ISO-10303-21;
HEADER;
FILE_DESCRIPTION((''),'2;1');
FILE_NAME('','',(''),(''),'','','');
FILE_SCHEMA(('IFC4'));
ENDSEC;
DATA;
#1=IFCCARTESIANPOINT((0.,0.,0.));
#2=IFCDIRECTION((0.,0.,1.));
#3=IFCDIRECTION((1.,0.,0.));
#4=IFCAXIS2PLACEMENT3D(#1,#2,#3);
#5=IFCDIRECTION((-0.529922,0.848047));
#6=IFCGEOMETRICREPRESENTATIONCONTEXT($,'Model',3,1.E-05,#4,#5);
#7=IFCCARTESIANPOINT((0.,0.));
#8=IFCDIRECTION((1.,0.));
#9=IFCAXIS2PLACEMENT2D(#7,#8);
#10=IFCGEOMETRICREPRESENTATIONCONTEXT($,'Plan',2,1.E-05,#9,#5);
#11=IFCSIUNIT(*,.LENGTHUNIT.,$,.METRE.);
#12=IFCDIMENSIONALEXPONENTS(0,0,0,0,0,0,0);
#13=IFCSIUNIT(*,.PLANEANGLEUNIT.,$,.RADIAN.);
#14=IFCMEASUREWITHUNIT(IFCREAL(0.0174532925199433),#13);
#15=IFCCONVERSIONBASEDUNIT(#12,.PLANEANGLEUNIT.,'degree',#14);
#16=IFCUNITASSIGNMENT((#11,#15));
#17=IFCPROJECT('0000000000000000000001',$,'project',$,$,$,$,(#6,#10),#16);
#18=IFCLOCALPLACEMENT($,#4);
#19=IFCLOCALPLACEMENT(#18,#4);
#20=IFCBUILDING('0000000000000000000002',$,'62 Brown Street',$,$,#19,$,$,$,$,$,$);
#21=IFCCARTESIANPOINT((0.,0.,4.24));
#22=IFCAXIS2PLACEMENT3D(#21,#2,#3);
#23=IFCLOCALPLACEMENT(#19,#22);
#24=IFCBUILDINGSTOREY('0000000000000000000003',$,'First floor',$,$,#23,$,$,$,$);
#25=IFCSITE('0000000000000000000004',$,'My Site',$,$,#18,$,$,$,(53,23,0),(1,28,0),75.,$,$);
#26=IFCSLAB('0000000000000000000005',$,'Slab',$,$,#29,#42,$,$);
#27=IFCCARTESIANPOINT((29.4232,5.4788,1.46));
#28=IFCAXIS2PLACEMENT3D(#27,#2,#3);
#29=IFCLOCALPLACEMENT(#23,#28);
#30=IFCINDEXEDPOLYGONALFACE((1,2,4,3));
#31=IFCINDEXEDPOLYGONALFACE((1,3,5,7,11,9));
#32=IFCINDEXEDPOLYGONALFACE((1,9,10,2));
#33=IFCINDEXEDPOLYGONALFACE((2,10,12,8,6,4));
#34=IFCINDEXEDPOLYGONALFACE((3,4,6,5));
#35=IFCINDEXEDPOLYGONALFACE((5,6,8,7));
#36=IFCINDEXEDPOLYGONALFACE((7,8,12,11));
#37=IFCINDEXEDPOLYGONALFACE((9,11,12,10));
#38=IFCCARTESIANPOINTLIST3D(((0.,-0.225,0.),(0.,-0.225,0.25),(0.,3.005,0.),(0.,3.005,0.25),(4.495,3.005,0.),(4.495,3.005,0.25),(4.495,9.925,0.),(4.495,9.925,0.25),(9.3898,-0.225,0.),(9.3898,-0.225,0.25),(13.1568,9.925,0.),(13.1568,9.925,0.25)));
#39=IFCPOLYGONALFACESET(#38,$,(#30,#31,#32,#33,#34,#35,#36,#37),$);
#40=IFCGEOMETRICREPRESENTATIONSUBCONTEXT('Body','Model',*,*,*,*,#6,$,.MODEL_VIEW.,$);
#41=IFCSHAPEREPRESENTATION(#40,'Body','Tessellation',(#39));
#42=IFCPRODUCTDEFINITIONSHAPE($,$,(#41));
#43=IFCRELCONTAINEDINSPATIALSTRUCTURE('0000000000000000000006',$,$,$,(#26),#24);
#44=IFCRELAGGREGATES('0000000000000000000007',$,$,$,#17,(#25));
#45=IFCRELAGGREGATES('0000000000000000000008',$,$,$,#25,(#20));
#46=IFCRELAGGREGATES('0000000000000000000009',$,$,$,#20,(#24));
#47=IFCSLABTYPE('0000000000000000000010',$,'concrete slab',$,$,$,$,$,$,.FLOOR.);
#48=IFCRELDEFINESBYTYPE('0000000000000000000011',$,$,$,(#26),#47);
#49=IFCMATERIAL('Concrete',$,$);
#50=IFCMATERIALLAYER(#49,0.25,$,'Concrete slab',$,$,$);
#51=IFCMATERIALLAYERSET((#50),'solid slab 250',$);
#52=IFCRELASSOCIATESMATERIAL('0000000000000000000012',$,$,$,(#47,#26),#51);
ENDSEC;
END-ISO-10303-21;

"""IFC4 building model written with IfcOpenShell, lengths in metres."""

from ifc_helpers import new_model, entity, si_unit, converted_unit, direction, frame, origin_with_axes, origin_2d_with_axis, place, context, subcontext, project, spatial, line, indexed_curve, outline, extrude, material, layer, layer_set, layer_usage, type_object, element, save


model = new_model("IFC4")

# Units and contexts
model_context = context("Model", 3, precision=1e-05, world=origin_with_axes(), true_north=direction((-0.529922, 0.848047)))
plan_context = context("Plan", 2, precision=1e-05, world=origin_2d_with_axis(), true_north=direction((-0.529922, 0.848047)))
body_context_1 = subcontext(model_context, "Body", "Model", "MODEL_VIEW")
ifc_project = project(units=[si_unit("LENGTHUNIT", "METRE"), converted_unit("PLANEANGLEUNIT", "degree", entity("IfcReal", 0.0174532925199433), si_unit("PLANEANGLEUNIT", "RADIAN"), dimensions=[0, 0, 0, 0, 0, 0, 0])], contexts=[model_context, plan_context])

# Site, building, storey
site_placement = place(None, origin_with_axes())
site = spatial("IfcSite", under=ifc_project, at=site_placement, Name="My Site", RefLatitude=(53, 23, 0), RefLongitude=(1, 28, 0), RefElevation=75.0)
building_placement = place(site_placement, origin_with_axes())
building = spatial("IfcBuilding", under=site, at=building_placement, Name="62 Brown Street")
storey_placement = place(building_placement, frame((0.0, 0.0, 4.24), z_axis=(0.0, 0.0, 1.0), x_axis=(1.0, 0.0, 0.0)))
storey = spatial("IfcBuildingStorey", under=building, at=storey_placement, Name="First floor")

# Slab
ifc_material_1 = material(Name="Concrete")
ifc_layer_1 = layer(ifc_material_1, 0.25, Name="Concrete slab")
ifc_layer_set_1 = layer_set([ifc_layer_1], Name="solid slab 250")
slab_type = type_object("IfcSlabType", Name="concrete slab", PredefinedType="FLOOR", material=ifc_layer_set_1)
ifc_layer_usage_1 = layer_usage(ifc_layer_set_1, "AXIS3", "POSITIVE", 0.0)
slab_1_placement = place(storey_placement, frame((29.4232, 5.4788, 1.46), z_axis=(0.0, 0.0, 1.0), x_axis=(1.0, 0.0, 0.0)))
element("IfcSlab", 1, at=slab_1_placement, inside=storey, type_object=slab_type, material=ifc_layer_usage_1, Name="Slab", context=body_context_1, shape_type="SweptSolid", body=[
    extrude(outline(indexed_curve([(0.0, 3.005), (0.0, -0.225), (9.3898, -0.225), (13.1568, 9.925), (4.495, 9.925), (4.495, 3.005)], segments=[line(4, 3), line(3, 2), line(2, 1), line(1, 6), line(6, 5), line(5, 4)], self_intersect=False)), None, (0.0, 0.0, 1.0), 0.25),
])

save(model, "model.ifc")
